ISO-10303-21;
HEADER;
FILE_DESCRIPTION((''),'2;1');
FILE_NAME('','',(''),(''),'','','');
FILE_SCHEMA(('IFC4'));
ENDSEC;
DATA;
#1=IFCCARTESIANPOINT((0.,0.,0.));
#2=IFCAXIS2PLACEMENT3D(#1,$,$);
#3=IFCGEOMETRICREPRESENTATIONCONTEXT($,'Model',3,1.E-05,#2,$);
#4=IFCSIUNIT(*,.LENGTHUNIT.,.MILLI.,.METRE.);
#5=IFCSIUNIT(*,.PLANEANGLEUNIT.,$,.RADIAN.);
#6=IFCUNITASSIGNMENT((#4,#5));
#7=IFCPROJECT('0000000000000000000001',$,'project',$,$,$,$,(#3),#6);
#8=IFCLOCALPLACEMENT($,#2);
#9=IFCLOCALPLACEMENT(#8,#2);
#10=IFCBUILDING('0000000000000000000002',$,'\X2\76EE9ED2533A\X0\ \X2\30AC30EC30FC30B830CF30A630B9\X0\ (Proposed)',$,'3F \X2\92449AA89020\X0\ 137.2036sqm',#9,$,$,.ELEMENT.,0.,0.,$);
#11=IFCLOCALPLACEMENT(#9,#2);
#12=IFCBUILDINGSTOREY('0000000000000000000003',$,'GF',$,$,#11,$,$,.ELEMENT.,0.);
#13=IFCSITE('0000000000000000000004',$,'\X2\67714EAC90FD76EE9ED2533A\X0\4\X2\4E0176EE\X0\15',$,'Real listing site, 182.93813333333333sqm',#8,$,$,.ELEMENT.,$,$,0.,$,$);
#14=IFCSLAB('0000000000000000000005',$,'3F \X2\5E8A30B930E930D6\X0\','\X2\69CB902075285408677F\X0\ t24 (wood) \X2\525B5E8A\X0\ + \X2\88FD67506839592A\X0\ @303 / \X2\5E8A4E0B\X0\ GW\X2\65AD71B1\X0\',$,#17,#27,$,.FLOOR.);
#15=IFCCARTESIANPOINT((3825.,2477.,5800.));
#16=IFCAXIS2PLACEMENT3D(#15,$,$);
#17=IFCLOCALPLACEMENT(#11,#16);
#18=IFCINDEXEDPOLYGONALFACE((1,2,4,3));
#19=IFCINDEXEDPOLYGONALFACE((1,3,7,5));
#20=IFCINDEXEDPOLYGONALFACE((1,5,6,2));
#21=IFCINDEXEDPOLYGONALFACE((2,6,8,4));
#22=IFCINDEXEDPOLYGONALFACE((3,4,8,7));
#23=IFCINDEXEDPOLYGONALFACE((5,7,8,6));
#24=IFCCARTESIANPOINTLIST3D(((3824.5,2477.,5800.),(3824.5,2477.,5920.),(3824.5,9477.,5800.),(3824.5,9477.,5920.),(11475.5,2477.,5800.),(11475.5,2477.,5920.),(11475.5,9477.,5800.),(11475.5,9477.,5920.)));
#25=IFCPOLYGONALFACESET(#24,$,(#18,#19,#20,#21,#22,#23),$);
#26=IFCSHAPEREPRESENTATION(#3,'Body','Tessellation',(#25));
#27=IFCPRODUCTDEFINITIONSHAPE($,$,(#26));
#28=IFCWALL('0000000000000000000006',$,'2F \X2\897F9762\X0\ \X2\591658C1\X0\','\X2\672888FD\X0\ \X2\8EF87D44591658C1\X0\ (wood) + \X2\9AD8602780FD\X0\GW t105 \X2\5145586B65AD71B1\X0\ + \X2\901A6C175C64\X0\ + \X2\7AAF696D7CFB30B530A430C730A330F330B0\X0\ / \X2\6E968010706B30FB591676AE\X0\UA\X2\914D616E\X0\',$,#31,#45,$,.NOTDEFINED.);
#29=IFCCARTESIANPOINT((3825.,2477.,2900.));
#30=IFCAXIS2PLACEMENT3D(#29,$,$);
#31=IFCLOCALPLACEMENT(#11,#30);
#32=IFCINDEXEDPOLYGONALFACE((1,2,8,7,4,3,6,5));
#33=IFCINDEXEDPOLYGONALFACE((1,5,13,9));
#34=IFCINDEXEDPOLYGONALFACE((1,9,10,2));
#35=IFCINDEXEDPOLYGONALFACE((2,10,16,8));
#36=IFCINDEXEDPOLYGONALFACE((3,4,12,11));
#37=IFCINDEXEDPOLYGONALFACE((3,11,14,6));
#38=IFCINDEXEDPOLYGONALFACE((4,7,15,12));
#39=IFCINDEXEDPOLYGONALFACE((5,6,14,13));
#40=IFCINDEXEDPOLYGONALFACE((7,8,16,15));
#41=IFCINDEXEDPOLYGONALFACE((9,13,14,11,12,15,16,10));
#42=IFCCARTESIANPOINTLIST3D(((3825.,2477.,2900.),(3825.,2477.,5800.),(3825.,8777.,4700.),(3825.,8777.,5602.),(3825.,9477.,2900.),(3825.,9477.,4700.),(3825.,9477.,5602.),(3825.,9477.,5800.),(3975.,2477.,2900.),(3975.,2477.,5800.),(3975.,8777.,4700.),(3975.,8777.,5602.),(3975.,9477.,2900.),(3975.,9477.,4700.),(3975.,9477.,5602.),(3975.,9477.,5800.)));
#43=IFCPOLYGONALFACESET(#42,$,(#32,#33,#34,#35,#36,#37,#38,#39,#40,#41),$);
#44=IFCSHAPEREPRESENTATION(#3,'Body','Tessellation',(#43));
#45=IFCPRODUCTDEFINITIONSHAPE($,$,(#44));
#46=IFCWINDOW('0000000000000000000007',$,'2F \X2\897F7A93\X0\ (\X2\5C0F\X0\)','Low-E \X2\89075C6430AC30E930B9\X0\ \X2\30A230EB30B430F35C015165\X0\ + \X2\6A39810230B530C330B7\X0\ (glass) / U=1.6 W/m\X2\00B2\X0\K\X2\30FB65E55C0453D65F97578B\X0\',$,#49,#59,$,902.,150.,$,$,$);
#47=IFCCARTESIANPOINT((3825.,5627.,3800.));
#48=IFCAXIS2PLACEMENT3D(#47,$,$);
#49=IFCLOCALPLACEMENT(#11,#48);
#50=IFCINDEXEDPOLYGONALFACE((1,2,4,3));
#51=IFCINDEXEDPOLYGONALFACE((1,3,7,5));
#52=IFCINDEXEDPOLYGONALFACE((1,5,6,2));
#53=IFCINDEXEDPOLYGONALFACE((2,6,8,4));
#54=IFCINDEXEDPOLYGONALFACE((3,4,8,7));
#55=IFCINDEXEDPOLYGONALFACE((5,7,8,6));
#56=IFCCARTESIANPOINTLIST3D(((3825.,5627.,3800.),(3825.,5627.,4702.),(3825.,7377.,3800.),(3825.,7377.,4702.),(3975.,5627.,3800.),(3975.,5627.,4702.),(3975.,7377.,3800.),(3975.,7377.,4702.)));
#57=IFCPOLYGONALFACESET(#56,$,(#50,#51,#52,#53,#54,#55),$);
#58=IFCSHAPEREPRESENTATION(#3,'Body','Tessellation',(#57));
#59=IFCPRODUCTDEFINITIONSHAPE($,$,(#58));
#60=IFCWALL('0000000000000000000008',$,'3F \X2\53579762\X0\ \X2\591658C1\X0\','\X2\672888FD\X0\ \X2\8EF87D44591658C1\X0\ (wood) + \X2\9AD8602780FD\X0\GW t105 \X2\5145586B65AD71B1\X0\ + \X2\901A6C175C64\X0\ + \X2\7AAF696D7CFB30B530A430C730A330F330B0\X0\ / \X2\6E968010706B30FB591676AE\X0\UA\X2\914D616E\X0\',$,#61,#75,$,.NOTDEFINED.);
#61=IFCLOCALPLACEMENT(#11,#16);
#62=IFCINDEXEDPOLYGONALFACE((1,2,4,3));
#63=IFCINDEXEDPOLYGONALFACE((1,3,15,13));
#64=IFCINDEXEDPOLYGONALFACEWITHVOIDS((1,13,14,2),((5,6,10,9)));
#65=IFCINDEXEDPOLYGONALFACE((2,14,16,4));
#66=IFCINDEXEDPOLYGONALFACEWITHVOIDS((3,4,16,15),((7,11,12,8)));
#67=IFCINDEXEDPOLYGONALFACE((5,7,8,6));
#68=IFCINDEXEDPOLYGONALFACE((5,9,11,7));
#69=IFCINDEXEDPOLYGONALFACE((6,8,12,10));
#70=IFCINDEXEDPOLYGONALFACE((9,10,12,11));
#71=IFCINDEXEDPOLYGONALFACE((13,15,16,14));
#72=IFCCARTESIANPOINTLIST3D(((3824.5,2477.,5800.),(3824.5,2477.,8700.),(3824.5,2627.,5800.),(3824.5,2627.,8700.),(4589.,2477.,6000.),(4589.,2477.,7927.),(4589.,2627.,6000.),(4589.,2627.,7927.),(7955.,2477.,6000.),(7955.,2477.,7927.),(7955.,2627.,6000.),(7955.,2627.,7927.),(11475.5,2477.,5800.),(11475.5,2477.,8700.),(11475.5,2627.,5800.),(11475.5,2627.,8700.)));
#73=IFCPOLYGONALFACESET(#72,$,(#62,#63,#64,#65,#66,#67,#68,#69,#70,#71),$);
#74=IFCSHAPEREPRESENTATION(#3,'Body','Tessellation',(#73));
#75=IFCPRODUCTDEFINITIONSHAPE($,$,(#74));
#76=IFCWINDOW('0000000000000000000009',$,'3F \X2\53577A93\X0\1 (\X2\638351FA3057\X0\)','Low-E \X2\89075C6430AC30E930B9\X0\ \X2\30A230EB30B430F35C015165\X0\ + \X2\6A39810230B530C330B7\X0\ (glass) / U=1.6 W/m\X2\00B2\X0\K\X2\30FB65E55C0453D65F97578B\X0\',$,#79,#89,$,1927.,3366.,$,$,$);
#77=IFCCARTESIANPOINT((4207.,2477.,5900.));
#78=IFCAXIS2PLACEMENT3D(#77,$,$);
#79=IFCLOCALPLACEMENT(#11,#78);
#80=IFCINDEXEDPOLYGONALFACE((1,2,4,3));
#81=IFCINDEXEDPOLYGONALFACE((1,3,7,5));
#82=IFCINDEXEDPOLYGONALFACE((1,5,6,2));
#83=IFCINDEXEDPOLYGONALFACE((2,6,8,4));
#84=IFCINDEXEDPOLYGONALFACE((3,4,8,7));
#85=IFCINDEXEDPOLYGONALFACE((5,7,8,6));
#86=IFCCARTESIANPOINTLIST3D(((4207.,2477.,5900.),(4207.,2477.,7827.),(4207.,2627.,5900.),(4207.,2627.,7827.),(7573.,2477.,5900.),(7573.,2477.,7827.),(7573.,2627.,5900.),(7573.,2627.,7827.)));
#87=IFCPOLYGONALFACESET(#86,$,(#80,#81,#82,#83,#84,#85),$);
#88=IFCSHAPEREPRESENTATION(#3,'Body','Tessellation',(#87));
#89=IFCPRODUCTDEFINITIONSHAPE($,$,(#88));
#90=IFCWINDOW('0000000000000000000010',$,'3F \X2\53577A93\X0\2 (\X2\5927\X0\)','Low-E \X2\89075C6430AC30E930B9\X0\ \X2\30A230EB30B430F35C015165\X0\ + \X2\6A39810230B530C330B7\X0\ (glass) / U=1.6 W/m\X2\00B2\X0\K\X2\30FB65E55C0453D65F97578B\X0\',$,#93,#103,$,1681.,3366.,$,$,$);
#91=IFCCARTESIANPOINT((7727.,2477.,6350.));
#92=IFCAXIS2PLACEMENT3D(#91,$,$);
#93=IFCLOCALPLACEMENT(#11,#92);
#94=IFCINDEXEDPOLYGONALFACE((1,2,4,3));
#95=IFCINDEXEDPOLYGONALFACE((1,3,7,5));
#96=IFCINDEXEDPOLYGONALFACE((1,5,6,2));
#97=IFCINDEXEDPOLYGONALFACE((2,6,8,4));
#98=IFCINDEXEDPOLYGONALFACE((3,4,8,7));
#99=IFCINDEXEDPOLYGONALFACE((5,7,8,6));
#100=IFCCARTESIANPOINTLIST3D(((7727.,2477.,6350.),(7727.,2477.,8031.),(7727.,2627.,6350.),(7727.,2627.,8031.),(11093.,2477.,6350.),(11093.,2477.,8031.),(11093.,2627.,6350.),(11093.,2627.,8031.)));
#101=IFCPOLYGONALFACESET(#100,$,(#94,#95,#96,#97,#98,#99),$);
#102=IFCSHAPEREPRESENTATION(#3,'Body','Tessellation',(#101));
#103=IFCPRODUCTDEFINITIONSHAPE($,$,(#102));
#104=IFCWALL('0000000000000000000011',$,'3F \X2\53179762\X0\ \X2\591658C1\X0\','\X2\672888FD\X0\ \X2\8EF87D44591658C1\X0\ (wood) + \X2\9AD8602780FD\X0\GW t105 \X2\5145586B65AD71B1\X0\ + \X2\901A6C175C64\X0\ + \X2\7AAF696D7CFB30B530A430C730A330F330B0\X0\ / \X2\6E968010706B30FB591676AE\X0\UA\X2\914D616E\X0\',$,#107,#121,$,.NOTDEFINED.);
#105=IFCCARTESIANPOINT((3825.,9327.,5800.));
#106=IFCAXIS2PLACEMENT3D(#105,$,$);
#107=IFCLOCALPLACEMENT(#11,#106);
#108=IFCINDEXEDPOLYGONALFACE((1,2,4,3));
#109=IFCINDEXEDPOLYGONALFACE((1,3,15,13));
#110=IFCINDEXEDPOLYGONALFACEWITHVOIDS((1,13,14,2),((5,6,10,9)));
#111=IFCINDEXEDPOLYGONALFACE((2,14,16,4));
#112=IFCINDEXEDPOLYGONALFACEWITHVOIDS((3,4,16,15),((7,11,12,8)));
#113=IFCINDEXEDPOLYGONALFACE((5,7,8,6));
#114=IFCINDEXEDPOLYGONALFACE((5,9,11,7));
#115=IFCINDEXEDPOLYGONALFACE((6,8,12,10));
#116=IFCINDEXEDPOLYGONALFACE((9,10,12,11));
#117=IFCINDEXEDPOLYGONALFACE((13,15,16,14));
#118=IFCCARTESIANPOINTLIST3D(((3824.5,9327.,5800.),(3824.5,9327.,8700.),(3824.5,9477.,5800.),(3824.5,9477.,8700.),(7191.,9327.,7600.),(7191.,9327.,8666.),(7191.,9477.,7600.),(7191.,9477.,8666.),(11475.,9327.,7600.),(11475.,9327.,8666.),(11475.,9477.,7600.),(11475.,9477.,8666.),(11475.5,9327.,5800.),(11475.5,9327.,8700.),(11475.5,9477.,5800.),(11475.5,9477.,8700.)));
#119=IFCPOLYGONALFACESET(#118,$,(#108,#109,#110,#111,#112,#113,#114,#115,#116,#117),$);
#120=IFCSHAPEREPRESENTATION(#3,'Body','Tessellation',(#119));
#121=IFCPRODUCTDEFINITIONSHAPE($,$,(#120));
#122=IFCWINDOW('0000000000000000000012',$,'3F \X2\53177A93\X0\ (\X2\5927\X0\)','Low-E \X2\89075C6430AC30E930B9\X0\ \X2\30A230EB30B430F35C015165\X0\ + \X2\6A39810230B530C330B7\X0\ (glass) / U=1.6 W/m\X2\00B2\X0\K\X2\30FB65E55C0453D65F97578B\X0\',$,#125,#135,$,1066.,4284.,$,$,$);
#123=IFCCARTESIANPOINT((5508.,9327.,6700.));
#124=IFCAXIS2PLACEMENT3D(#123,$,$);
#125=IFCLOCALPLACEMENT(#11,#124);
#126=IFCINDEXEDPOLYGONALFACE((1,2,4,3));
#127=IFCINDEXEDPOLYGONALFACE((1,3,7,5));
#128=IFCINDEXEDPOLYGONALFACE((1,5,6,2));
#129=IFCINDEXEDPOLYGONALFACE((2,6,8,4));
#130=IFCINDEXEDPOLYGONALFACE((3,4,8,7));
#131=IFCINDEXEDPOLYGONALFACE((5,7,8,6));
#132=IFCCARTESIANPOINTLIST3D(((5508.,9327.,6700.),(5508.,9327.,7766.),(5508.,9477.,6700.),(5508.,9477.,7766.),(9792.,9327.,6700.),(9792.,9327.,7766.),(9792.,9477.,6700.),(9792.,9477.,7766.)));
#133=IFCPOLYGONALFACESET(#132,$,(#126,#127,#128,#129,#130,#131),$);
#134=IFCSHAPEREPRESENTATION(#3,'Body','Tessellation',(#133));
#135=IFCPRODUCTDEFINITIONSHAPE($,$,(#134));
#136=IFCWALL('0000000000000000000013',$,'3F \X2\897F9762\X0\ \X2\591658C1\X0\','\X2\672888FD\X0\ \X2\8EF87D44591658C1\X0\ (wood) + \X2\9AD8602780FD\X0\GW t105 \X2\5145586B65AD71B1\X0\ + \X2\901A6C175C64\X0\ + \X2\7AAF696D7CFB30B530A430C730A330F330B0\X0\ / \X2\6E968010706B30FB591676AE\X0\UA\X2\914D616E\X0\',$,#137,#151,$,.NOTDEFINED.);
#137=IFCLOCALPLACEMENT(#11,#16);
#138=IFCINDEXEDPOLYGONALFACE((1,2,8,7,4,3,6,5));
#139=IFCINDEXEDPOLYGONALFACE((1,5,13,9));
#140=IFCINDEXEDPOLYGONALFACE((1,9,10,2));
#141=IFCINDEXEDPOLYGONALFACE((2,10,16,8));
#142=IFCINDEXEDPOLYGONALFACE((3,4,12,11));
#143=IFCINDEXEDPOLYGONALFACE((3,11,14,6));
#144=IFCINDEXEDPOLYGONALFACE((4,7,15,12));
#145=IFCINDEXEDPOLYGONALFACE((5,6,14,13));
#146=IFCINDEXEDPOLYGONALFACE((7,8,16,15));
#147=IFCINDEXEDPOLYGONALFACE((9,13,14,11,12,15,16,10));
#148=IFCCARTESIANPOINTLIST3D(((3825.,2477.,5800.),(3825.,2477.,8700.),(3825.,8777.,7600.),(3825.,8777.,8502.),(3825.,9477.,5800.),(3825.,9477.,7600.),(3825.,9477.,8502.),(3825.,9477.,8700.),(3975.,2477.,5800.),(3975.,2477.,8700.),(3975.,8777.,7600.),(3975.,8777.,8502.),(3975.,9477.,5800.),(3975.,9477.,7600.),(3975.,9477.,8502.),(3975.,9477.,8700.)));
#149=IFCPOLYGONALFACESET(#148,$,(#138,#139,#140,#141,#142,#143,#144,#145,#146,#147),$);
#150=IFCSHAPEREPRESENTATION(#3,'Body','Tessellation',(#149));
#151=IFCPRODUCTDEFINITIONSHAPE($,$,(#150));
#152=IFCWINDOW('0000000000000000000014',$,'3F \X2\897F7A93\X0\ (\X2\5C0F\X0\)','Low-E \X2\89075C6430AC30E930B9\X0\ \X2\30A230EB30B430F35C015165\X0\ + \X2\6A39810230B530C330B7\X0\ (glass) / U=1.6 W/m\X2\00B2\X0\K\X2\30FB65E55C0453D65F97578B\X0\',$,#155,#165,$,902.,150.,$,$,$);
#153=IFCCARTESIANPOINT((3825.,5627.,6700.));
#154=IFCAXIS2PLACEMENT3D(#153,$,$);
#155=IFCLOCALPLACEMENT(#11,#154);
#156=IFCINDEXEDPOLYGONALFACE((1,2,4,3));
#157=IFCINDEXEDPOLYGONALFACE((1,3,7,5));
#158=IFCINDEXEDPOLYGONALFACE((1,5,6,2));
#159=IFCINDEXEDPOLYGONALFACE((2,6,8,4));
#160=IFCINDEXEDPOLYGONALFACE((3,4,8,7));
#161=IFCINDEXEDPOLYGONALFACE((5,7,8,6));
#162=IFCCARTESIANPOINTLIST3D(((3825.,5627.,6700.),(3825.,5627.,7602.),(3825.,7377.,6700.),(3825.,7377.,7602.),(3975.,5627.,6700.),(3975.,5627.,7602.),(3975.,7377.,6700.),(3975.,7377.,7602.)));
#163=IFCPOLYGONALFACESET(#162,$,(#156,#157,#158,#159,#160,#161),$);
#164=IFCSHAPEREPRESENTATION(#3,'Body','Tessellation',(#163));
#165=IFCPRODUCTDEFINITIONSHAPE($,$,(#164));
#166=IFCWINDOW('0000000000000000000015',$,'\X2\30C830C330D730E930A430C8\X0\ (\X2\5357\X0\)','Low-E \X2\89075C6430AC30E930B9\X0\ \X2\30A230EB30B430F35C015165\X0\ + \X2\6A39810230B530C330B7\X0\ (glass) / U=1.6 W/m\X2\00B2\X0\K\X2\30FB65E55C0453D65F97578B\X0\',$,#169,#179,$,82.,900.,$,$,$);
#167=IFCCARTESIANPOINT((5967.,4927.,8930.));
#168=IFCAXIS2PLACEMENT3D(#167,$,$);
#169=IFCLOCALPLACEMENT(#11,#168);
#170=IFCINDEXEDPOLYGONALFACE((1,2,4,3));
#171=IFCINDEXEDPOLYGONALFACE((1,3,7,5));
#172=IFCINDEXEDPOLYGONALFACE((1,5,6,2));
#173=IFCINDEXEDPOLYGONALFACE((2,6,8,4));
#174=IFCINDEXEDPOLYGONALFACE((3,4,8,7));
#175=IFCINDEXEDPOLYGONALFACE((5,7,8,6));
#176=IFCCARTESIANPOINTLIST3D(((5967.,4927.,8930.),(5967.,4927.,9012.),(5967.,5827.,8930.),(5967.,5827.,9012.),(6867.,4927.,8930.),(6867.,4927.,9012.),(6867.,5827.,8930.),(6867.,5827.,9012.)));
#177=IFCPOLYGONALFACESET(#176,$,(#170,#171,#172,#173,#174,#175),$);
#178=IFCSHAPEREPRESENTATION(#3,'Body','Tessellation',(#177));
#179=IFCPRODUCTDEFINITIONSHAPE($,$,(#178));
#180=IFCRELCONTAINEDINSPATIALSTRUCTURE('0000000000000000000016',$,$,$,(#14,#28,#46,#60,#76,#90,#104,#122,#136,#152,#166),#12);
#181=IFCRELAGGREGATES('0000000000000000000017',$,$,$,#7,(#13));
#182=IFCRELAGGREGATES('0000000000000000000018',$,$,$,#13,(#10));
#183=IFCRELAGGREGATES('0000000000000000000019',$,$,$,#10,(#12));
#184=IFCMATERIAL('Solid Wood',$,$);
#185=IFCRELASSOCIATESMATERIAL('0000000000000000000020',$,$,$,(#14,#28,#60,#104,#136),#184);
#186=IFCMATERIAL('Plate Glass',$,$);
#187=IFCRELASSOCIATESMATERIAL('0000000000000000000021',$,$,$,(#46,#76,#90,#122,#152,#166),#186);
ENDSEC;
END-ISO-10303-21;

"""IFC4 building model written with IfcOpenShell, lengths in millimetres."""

from ifc_helpers import new_model, si_unit, frame, frame_2d, origin, place, context, project, spatial, rectangle, extrude, material, element, fill, save


model = new_model("IFC4")

# Units and contexts
model_context = context("Model", 3, precision=1e-05, world=origin())
ifc_project = project(units=[si_unit("LENGTHUNIT", "METRE", prefix="MILLI"), si_unit("PLANEANGLEUNIT", "RADIAN")], contexts=[model_context])

# Site, building, storey
site_placement = place(None, origin())
site = spatial("IfcSite", under=ifc_project, at=site_placement, Name="東京都目黒区4丁目15", ObjectType="Real listing site, 182.93813333333333sqm", CompositionType="ELEMENT", RefElevation=0.0)
building_placement = place(site_placement, origin())
building = spatial("IfcBuilding", under=site, at=building_placement, Name="目黒区 ガレージハウス (Proposed)", ObjectType="3F 鉄骨造 137.2036sqm", CompositionType="ELEMENT", ElevationOfRefHeight=0.0, ElevationOfTerrain=0.0)
storey_placement = place(building_placement, origin())
storey = spatial("IfcBuildingStorey", under=building, at=storey_placement, Name="GF", CompositionType="ELEMENT", Elevation=0.0)

# Slab
ifc_material_1 = material(Name="Solid Wood")
slab_placement = place(storey_placement, frame((3825.0, 2477.0, 5800.0)))
element("IfcSlab", 1, at=slab_placement, inside=storey, material=ifc_material_1, Name="3F 床スラブ", Description="構造用合板 t24 (wood) 剛床 + 製材根太 @303 / 床下 GW断熱", PredefinedType="FLOOR", context=model_context, shape_type="SweptSolid", body=[
    extrude(rectangle(XDim=7651.0, YDim=7000.0, at=frame_2d((3825.0, 3500.0))), frame((3825.0, 2477.0, 5800.0)), (0.0, 0.0, 1.0), 120.0),
])

# Wall, opening, window
wall_1_placement = place(storey_placement, frame((3825.0, 2477.0, 2900.0)))
wall_1 = element("IfcWall", 2, at=wall_1_placement, inside=storey, material=ifc_material_1, Name="2F 西面 外壁", Description="木製 軸組外壁 (wood) + 高性能GW t105 充填断熱 + 通気層 + 窯業系サイディング / 準耐火・外皮UA配慮", PredefinedType="NOTDEFINED", context=model_context, shape_type="SweptSolid", body=[
    extrude(rectangle(XDim=150.0, YDim=7000.0, at=frame_2d((75.0, 3500.0))), frame((3825.0, 2477.0, 2900.0)), (0.0, 0.0, 1.0), 2900.0),
])
opening_1_placement = place(storey_placement, frame((3825.0, 5627.0, 3800.0)))
opening_1 = element("IfcOpeningElement", 3, at=opening_1_placement, cuts=wall_1, PredefinedType="NOTDEFINED", context=model_context, shape_type="SweptSolid", body=[
    extrude(rectangle(XDim=150.0, YDim=1750.0, at=frame_2d((75.0, 875.0))), frame((3825.0, 5627.0, 3800.0)), (0.0, 0.0, 1.0), 902.0),
])
ifc_material_2 = material(Name="Plate Glass")
window_1_placement = place(storey_placement, frame((3825.0, 5627.0, 3800.0)))
window_1 = element("IfcWindow", 4, at=window_1_placement, inside=storey, material=ifc_material_2, Name="2F 西窓 (小)", Description="Low-E 複層ガラス アルゴン封入 + 樹脂サッシ (glass) / U=1.6 W/m²K・日射取得型", OverallHeight=902.0, OverallWidth=150.0, context=model_context, shape_type="SweptSolid", body=[
    extrude(rectangle(XDim=150.0, YDim=1750.0, at=frame_2d((75.0, 875.0))), frame((3825.0, 5627.0, 3800.0)), (0.0, 0.0, 1.0), 902.0),
])
fill(opening_1, window_1)

# Wall, openings, windows
wall_2_placement = place(storey_placement, frame((3825.0, 2477.0, 5800.0)))
wall_2 = element("IfcWall", 5, at=wall_2_placement, inside=storey, material=ifc_material_1, Name="3F 南面 外壁", Description="木製 軸組外壁 (wood) + 高性能GW t105 充填断熱 + 通気層 + 窯業系サイディング / 準耐火・外皮UA配慮", PredefinedType="NOTDEFINED", context=model_context, shape_type="SweptSolid", body=[
    extrude(rectangle(XDim=7651.0, YDim=150.0, at=frame_2d((3825.0, 75.0))), frame((3825.0, 2477.0, 5800.0)), (0.0, 0.0, 1.0), 2900.0),
])
opening_2_placement = place(storey_placement, frame((4207.0, 2477.0, 5900.0)))
opening_2 = element("IfcOpeningElement", 6, at=opening_2_placement, cuts=wall_2, PredefinedType="NOTDEFINED", context=model_context, shape_type="SweptSolid", body=[
    extrude(rectangle(XDim=3366.0, YDim=150.0, at=frame_2d((1683.0, 75.0))), frame((4207.0, 2477.0, 5900.0)), (0.0, 0.0, 1.0), 1927.0),
])
opening_3_placement = place(storey_placement, frame((7727.0, 2477.0, 6350.0)))
opening_3 = element("IfcOpeningElement", 7, at=opening_3_placement, cuts=wall_2, PredefinedType="NOTDEFINED", context=model_context, shape_type="SweptSolid", body=[
    extrude(rectangle(XDim=3366.0, YDim=150.0, at=frame_2d((1683.0, 75.0))), frame((7727.0, 2477.0, 6350.0)), (0.0, 0.0, 1.0), 1681.0),
])
window_2_placement = place(storey_placement, frame((4207.0, 2477.0, 5900.0)))
window_2 = element("IfcWindow", 8, at=window_2_placement, inside=storey, material=ifc_material_2, Name="3F 南窓1 (掃出し)", Description="Low-E 複層ガラス アルゴン封入 + 樹脂サッシ (glass) / U=1.6 W/m²K・日射取得型", OverallHeight=1927.0, OverallWidth=3366.0, context=model_context, shape_type="SweptSolid", body=[
    extrude(rectangle(XDim=3366.0, YDim=150.0, at=frame_2d((1683.0, 75.0))), frame((4207.0, 2477.0, 5900.0)), (0.0, 0.0, 1.0), 1927.0),
])
fill(opening_2, window_2)
window_3_placement = place(storey_placement, frame((7727.0, 2477.0, 6350.0)))
window_3 = element("IfcWindow", 9, at=window_3_placement, inside=storey, material=ifc_material_2, Name="3F 南窓2 (大)", Description="Low-E 複層ガラス アルゴン封入 + 樹脂サッシ (glass) / U=1.6 W/m²K・日射取得型", OverallHeight=1681.0, OverallWidth=3366.0, context=model_context, shape_type="SweptSolid", body=[
    extrude(rectangle(XDim=3366.0, YDim=150.0, at=frame_2d((1683.0, 75.0))), frame((7727.0, 2477.0, 6350.0)), (0.0, 0.0, 1.0), 1681.0),
])
fill(opening_3, window_3)

# Walls, openings, windows
wall_3_placement = place(storey_placement, frame((3825.0, 9327.0, 5800.0)))
wall_3 = element("IfcWall", 10, at=wall_3_placement, inside=storey, material=ifc_material_1, Name="3F 北面 外壁", Description="木製 軸組外壁 (wood) + 高性能GW t105 充填断熱 + 通気層 + 窯業系サイディング / 準耐火・外皮UA配慮", PredefinedType="NOTDEFINED", context=model_context, shape_type="SweptSolid", body=[
    extrude(rectangle(XDim=7651.0, YDim=150.0, at=frame_2d((3825.0, 75.0))), frame((3825.0, 9327.0, 5800.0)), (0.0, 0.0, 1.0), 2900.0),
])
opening_4_placement = place(storey_placement, frame((5508.0, 9327.0, 6700.0)))
opening_4 = element("IfcOpeningElement", 11, at=opening_4_placement, cuts=wall_3, PredefinedType="NOTDEFINED", context=model_context, shape_type="SweptSolid", body=[
    extrude(rectangle(XDim=4284.0, YDim=150.0, at=frame_2d((2142.0, 75.0))), frame((5508.0, 9327.0, 6700.0)), (0.0, 0.0, 1.0), 1066.0),
])
window_4_placement = place(storey_placement, frame((5508.0, 9327.0, 6700.0)))
window_4 = element("IfcWindow", 12, at=window_4_placement, inside=storey, material=ifc_material_2, Name="3F 北窓 (大)", Description="Low-E 複層ガラス アルゴン封入 + 樹脂サッシ (glass) / U=1.6 W/m²K・日射取得型", OverallHeight=1066.0, OverallWidth=4284.0, context=model_context, shape_type="SweptSolid", body=[
    extrude(rectangle(XDim=4284.0, YDim=150.0, at=frame_2d((2142.0, 75.0))), frame((5508.0, 9327.0, 6700.0)), (0.0, 0.0, 1.0), 1066.0),
])
fill(opening_4, window_4)
wall_4_placement = place(storey_placement, frame((3825.0, 2477.0, 5800.0)))
wall_4 = element("IfcWall", 13, at=wall_4_placement, inside=storey, material=ifc_material_1, Name="3F 西面 外壁", Description="木製 軸組外壁 (wood) + 高性能GW t105 充填断熱 + 通気層 + 窯業系サイディング / 準耐火・外皮UA配慮", PredefinedType="NOTDEFINED", context=model_context, shape_type="SweptSolid", body=[
    extrude(rectangle(XDim=150.0, YDim=7000.0, at=frame_2d((75.0, 3500.0))), frame((3825.0, 2477.0, 5800.0)), (0.0, 0.0, 1.0), 2900.0),
])
opening_5_placement = place(storey_placement, frame((3825.0, 5627.0, 6700.0)))
opening_5 = element("IfcOpeningElement", 14, at=opening_5_placement, cuts=wall_4, PredefinedType="NOTDEFINED", context=model_context, shape_type="SweptSolid", body=[
    extrude(rectangle(XDim=150.0, YDim=1750.0, at=frame_2d((75.0, 875.0))), frame((3825.0, 5627.0, 6700.0)), (0.0, 0.0, 1.0), 902.0),
])
window_5_placement = place(storey_placement, frame((3825.0, 5627.0, 6700.0)))
window_5 = element("IfcWindow", 15, at=window_5_placement, inside=storey, material=ifc_material_2, Name="3F 西窓 (小)", Description="Low-E 複層ガラス アルゴン封入 + 樹脂サッシ (glass) / U=1.6 W/m²K・日射取得型", OverallHeight=902.0, OverallWidth=150.0, context=model_context, shape_type="SweptSolid", body=[
    extrude(rectangle(XDim=150.0, YDim=1750.0, at=frame_2d((75.0, 875.0))), frame((3825.0, 5627.0, 6700.0)), (0.0, 0.0, 1.0), 902.0),
])
fill(opening_5, window_5)

# Window
window_6_placement = place(storey_placement, frame((5967.0, 4927.0, 8930.0)))
element("IfcWindow", 16, at=window_6_placement, inside=storey, material=ifc_material_2, Name="トップライト (南)", Description="Low-E 複層ガラス アルゴン封入 + 樹脂サッシ (glass) / U=1.6 W/m²K・日射取得型", OverallHeight=82.0, OverallWidth=900.0, context=model_context, shape_type="SweptSolid", body=[
    extrude(rectangle(XDim=900.0, YDim=900.0, at=frame_2d((450.0, 450.0))), frame((5967.0, 4927.0, 8930.0)), (0.0, 0.0, 1.0), 82.0),
])

save(model, "model.ifc")
